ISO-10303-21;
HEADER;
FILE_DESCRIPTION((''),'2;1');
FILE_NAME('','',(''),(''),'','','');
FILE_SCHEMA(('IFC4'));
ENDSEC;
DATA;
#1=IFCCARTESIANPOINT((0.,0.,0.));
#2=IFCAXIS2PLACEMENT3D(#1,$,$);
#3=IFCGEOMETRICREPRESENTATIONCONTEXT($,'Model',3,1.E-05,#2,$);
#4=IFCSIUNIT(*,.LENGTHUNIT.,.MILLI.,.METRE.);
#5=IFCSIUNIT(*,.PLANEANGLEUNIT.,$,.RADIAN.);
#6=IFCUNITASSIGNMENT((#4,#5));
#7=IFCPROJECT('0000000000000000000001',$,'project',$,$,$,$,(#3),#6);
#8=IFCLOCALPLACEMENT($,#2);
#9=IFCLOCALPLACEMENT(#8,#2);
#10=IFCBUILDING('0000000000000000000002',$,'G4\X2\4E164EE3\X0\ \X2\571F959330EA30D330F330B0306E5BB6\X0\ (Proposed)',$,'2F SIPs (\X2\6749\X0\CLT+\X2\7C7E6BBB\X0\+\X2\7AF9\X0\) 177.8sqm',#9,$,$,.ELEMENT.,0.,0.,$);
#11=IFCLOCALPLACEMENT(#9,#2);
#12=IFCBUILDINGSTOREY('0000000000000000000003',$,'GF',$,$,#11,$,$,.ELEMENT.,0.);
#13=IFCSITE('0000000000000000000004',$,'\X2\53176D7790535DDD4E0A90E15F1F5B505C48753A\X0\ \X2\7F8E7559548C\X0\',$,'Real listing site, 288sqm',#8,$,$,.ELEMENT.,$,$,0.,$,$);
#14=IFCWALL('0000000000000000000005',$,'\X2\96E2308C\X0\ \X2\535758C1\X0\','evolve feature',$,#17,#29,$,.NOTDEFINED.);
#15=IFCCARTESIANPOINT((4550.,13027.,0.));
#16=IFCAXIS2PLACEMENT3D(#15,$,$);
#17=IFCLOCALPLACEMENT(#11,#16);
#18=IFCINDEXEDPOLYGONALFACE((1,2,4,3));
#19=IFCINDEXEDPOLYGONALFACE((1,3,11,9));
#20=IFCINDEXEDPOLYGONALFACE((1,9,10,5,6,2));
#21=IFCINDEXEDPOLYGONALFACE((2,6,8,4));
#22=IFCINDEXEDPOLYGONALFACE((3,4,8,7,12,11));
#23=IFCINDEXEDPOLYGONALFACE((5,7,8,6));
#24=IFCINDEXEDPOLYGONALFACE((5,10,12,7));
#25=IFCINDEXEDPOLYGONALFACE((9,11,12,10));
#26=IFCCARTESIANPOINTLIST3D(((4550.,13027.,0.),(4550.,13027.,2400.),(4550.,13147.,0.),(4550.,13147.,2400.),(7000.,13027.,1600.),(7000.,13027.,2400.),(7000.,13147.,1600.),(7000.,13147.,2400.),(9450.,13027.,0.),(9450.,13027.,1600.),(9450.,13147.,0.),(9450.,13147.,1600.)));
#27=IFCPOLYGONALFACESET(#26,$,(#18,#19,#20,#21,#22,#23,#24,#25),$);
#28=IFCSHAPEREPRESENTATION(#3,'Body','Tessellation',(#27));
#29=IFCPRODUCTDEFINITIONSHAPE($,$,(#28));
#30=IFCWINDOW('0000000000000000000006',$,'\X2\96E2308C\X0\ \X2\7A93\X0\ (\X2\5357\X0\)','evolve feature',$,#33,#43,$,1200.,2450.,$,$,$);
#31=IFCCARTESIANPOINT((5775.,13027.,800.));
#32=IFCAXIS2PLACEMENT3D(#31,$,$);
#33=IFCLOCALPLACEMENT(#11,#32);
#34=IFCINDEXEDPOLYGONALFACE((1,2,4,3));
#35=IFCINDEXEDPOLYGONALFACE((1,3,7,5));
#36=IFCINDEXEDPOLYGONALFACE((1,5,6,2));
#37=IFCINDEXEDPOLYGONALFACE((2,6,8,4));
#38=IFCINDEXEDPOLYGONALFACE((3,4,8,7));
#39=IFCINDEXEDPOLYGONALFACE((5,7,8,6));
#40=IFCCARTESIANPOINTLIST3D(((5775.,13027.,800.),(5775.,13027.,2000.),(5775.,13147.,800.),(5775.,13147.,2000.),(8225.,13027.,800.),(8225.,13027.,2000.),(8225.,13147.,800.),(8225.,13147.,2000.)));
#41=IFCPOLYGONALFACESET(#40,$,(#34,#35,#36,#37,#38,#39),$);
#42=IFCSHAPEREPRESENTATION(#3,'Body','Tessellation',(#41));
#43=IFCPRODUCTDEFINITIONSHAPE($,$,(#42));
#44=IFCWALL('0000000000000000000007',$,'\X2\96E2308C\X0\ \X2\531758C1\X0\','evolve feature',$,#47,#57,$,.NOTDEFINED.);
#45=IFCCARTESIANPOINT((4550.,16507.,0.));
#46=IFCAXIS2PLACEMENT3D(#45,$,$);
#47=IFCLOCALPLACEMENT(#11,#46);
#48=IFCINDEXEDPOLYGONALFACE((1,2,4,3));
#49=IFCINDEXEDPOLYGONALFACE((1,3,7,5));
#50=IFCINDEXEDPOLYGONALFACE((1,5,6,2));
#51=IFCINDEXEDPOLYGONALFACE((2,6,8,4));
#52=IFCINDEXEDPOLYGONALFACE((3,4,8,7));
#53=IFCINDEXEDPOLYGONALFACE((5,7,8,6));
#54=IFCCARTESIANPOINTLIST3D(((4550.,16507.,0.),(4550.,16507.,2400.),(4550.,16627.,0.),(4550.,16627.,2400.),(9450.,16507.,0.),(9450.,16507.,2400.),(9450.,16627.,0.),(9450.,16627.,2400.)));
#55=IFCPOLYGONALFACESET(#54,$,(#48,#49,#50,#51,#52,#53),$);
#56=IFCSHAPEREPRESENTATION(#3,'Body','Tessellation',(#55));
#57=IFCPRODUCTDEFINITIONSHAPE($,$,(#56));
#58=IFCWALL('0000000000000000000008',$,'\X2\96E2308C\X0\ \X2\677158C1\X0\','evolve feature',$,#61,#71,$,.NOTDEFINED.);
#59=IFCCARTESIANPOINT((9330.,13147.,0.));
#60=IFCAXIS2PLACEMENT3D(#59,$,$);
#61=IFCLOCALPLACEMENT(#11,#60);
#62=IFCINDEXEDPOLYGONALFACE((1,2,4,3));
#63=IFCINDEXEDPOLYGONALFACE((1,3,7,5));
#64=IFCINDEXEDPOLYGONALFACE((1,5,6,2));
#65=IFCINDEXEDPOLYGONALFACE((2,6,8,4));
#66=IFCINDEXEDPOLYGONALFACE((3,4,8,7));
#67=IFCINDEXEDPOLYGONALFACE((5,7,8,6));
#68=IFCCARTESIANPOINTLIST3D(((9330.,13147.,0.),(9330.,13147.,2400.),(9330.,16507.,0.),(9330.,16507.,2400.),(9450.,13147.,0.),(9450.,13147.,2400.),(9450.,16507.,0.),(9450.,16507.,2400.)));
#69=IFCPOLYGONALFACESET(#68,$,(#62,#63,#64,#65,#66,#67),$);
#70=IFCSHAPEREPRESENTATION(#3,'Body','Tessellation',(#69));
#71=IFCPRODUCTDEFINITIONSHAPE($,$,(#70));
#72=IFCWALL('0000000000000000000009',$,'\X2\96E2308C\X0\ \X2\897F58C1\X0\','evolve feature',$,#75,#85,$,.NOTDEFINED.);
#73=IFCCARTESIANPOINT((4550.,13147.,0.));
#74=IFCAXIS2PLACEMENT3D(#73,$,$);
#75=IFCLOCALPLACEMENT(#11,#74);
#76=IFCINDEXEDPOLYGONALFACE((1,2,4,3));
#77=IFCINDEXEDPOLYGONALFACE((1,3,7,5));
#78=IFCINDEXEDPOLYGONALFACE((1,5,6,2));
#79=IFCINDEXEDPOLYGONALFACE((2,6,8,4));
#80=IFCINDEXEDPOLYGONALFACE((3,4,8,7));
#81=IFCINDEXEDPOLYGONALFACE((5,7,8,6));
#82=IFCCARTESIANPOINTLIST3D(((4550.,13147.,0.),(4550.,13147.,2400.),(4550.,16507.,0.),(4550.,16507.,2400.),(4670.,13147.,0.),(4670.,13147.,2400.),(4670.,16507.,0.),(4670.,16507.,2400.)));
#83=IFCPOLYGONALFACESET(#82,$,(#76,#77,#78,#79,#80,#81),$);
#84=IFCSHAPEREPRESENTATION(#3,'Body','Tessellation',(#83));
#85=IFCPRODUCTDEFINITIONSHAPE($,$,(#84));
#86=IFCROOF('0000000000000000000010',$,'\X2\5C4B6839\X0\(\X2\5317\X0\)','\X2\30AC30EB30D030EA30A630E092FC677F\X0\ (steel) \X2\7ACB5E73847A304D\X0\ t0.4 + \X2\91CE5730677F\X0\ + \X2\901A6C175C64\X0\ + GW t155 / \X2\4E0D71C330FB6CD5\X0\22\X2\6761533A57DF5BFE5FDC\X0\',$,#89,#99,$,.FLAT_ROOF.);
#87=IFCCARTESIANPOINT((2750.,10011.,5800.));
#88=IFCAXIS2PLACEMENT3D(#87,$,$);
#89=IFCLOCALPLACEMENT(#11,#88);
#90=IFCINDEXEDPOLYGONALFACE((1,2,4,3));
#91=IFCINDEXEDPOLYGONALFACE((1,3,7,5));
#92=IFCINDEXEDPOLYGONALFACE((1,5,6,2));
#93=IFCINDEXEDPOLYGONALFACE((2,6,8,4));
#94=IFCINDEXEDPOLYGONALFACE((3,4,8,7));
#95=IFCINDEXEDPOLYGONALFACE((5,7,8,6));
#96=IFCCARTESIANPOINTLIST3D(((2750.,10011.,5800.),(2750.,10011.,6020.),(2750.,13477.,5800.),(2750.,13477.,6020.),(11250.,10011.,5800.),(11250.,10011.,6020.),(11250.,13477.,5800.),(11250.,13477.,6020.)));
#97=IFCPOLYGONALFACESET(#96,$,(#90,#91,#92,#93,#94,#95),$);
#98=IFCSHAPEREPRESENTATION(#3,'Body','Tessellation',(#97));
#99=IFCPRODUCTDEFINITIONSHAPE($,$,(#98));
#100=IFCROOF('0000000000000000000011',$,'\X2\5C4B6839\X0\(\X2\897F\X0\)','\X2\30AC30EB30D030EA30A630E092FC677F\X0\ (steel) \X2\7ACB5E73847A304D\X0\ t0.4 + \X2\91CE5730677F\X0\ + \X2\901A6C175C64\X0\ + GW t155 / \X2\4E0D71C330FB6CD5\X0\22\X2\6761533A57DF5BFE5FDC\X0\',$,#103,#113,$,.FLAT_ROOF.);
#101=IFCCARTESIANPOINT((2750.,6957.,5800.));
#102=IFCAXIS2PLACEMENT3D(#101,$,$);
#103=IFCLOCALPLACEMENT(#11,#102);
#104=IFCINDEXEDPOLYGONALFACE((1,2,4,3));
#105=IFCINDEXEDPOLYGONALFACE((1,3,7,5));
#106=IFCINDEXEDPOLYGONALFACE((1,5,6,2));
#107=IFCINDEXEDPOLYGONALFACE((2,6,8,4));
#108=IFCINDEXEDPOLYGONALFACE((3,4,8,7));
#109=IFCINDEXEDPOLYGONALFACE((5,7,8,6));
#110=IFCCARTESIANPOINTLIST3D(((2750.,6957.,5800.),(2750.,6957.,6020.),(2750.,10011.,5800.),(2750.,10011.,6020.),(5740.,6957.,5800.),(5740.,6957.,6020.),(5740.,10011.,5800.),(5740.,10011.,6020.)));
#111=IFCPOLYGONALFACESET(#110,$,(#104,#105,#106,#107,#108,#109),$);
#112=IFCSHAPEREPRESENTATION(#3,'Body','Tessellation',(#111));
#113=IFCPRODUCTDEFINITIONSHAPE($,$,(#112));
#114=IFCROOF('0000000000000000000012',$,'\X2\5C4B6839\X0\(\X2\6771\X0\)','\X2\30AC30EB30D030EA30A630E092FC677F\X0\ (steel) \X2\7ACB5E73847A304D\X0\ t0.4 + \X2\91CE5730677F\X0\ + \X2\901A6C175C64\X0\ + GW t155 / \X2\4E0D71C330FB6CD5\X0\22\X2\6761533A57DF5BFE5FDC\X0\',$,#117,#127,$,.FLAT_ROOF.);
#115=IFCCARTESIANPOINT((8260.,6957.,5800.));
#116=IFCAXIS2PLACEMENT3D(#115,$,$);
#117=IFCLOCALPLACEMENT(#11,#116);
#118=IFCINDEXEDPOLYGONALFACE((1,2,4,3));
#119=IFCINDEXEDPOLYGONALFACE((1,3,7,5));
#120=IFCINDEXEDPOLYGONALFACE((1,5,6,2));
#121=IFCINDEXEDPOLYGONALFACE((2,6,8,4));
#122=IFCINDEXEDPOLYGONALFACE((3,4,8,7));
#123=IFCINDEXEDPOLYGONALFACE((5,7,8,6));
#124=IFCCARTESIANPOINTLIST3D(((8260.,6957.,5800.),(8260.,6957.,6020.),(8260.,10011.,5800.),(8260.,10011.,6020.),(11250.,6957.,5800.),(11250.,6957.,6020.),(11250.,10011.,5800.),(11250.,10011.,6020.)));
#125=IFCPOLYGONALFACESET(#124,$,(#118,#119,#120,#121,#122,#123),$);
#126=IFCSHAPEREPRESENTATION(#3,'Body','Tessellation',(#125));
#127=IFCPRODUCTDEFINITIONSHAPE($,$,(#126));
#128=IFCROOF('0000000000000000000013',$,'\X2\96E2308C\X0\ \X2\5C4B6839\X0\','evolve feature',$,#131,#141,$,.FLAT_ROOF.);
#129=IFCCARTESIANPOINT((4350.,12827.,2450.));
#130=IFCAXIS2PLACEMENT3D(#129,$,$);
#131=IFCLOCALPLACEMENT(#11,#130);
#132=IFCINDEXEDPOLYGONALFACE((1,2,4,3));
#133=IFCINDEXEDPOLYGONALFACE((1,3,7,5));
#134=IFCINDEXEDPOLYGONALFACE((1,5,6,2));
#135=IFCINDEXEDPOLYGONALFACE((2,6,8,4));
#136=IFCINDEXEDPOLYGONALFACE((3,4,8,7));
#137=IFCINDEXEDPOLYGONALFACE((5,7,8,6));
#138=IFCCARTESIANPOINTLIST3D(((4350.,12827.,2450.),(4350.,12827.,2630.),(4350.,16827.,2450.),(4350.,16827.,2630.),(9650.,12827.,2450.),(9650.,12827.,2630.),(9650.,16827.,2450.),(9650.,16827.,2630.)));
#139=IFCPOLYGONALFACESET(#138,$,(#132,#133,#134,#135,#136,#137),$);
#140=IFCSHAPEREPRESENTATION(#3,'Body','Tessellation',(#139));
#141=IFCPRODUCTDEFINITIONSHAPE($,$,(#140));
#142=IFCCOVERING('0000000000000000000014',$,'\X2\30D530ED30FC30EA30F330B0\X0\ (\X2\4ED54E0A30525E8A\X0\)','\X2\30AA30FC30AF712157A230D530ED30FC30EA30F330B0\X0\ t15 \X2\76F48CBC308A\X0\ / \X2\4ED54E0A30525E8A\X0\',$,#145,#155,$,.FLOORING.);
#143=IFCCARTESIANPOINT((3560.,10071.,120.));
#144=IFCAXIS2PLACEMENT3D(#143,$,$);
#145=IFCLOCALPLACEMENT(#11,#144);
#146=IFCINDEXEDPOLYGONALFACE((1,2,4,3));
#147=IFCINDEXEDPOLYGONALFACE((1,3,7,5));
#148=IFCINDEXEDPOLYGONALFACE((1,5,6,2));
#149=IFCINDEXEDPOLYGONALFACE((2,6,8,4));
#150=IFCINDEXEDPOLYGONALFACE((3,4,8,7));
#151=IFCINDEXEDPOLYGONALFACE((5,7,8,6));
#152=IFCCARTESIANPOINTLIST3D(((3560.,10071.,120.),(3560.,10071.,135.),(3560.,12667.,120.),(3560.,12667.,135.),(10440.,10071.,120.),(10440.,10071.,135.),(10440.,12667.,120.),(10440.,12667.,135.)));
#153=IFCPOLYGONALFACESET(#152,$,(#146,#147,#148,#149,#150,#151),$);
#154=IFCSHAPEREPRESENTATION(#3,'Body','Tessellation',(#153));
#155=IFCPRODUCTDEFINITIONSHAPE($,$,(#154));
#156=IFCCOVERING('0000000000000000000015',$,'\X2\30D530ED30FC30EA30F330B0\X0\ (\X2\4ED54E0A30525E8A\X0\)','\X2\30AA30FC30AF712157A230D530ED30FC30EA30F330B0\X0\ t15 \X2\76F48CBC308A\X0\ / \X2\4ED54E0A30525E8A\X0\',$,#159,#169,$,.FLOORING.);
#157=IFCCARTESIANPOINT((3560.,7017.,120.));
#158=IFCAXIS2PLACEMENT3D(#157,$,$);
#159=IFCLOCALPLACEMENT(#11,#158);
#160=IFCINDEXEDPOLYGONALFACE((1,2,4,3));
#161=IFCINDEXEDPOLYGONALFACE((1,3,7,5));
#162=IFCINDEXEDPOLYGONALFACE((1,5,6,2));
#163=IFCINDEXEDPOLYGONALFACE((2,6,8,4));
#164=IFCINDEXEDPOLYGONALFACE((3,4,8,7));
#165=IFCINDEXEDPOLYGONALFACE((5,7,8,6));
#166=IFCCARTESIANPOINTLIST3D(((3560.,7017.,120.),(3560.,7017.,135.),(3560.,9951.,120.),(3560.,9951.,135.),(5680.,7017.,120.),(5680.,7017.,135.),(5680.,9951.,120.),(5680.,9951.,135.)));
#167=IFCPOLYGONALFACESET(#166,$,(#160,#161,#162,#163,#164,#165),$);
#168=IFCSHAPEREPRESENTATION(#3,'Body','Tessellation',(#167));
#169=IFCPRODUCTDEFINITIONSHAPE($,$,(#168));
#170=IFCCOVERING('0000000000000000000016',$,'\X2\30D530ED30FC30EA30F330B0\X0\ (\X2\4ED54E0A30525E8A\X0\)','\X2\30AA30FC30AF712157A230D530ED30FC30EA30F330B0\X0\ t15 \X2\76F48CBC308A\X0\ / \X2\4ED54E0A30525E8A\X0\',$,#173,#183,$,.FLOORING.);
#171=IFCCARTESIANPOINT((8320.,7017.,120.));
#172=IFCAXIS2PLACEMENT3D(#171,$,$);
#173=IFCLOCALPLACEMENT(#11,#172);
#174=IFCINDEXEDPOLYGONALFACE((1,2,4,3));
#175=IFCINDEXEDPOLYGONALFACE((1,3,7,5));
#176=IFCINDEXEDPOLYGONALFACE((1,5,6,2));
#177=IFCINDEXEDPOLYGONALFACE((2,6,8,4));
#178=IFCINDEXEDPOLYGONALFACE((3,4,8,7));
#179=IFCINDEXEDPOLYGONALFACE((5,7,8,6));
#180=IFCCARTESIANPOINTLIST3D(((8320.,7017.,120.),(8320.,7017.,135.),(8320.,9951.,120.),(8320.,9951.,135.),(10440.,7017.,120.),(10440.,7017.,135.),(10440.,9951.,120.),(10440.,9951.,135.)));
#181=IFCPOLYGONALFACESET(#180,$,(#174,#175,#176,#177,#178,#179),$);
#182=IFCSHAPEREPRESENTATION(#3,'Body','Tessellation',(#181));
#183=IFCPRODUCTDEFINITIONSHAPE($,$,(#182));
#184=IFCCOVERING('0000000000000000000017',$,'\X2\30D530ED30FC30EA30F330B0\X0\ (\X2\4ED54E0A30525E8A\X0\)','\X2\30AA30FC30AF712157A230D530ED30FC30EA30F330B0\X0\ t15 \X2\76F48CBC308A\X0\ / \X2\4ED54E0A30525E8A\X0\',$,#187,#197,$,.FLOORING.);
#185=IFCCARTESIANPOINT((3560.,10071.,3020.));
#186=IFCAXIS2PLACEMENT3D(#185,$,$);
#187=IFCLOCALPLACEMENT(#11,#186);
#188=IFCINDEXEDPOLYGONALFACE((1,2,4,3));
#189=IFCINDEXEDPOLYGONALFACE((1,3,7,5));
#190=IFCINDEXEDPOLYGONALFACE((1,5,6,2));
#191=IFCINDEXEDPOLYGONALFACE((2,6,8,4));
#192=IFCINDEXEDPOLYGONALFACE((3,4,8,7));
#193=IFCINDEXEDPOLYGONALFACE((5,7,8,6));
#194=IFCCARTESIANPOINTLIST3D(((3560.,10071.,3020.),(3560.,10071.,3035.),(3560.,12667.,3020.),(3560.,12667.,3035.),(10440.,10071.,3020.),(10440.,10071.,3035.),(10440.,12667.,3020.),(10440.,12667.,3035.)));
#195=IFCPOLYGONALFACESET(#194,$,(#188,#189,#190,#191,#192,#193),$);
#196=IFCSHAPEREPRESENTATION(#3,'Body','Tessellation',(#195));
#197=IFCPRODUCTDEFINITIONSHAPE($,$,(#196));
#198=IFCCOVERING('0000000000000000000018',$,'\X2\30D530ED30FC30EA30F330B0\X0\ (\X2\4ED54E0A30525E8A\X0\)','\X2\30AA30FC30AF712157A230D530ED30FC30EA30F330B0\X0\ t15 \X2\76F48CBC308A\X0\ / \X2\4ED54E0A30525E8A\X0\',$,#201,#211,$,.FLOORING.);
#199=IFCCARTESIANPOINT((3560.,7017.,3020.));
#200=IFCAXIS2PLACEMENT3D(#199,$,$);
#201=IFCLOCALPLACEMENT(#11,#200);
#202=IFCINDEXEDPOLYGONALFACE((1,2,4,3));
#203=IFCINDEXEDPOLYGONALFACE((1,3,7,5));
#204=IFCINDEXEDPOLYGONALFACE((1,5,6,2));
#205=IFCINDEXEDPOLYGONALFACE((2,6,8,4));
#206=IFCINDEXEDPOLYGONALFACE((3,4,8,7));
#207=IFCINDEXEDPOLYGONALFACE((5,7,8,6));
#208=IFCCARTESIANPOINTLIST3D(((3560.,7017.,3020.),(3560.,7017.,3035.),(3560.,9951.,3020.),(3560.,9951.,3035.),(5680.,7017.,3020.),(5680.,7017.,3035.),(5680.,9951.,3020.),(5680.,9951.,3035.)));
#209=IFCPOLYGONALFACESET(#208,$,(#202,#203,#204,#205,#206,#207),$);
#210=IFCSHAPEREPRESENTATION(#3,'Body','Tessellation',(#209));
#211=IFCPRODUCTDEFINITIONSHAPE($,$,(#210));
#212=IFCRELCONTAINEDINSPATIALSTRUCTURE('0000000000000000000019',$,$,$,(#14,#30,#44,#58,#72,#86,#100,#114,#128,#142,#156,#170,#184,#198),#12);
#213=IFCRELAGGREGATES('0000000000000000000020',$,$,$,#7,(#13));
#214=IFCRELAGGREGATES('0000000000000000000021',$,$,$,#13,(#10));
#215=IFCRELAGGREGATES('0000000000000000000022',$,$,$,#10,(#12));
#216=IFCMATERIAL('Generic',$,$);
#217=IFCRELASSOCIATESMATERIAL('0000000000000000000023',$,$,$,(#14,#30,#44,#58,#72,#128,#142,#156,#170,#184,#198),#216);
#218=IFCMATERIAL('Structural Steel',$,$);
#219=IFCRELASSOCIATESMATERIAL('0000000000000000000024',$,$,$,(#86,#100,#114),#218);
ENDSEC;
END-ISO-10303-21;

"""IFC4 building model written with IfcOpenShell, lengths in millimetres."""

from ifc_helpers import new_model, si_unit, frame, frame_2d, origin, place, context, project, spatial, rectangle, extrude, material, element, fill, save


model = new_model("IFC4")

# Units and contexts
model_context = context("Model", 3, precision=1e-05, world=origin())
ifc_project = project(units=[si_unit("LENGTHUNIT", "METRE", prefix="MILLI"), si_unit("PLANEANGLEUNIT", "RADIAN")], contexts=[model_context])

# Site, building, storey
site_placement = place(None, origin())
site = spatial("IfcSite", under=ifc_project, at=site_placement, Name="北海道川上郡弟子屈町 美留和", ObjectType="Real listing site, 288sqm", CompositionType="ELEMENT", RefElevation=0.0)
building_placement = place(site_placement, origin())
building = spatial("IfcBuilding", under=site, at=building_placement, Name="G4世代 土間リビングの家 (Proposed)", ObjectType="2F SIPs (杉CLT+籾殻+竹) 177.8sqm", CompositionType="ELEMENT", ElevationOfRefHeight=0.0, ElevationOfTerrain=0.0)
storey_placement = place(building_placement, origin())
storey = spatial("IfcBuildingStorey", under=building, at=storey_placement, Name="GF", CompositionType="ELEMENT", Elevation=0.0)

# Shared definitions
ifc_material_1 = material(Name="Generic")

# Wall, opening, window
wall_1_placement = place(storey_placement, frame((4550.0, 13027.0, 0.0)))
wall_1 = element("IfcWall", 1, at=wall_1_placement, inside=storey, material=ifc_material_1, Name="離れ 南壁", Description="evolve feature", PredefinedType="NOTDEFINED", context=model_context, shape_type="SweptSolid", body=[
    extrude(rectangle(XDim=4900.0, YDim=120.0, at=frame_2d((2450.0, 60.0))), frame((4550.0, 13027.0, 0.0)), (0.0, 0.0, 1.0), 2400.0),
])
opening_1_placement = place(storey_placement, frame((5775.0, 13027.0, 800.0)))
opening_1 = element("IfcOpeningElement", 2, at=opening_1_placement, cuts=wall_1, PredefinedType="NOTDEFINED", context=model_context, shape_type="SweptSolid", body=[
    extrude(rectangle(XDim=2450.0, YDim=120.0, at=frame_2d((1225.0, 60.0))), frame((5775.0, 13027.0, 800.0)), (0.0, 0.0, 1.0), 1200.0),
])
window_1_placement = place(storey_placement, frame((5775.0, 13027.0, 800.0)))
window_1 = element("IfcWindow", 3, at=window_1_placement, inside=storey, material=ifc_material_1, Name="離れ 窓 (南)", Description="evolve feature", OverallHeight=1200.0, OverallWidth=2450.0, context=model_context, shape_type="SweptSolid", body=[
    extrude(rectangle(XDim=2450.0, YDim=120.0, at=frame_2d((1225.0, 60.0))), frame((5775.0, 13027.0, 800.0)), (0.0, 0.0, 1.0), 1200.0),
])
fill(opening_1, window_1)

# Walls
wall_2_placement = place(storey_placement, frame((4550.0, 16507.0, 0.0)))
element("IfcWall", 4, at=wall_2_placement, inside=storey, material=ifc_material_1, Name="離れ 北壁", Description="evolve feature", PredefinedType="NOTDEFINED", context=model_context, shape_type="SweptSolid", body=[
    extrude(rectangle(XDim=4900.0, YDim=120.0, at=frame_2d((2450.0, 60.0))), frame((4550.0, 16507.0, 0.0)), (0.0, 0.0, 1.0), 2400.0),
])
wall_3_placement = place(storey_placement, frame((9330.0, 13147.0, 0.0)))
element("IfcWall", 5, at=wall_3_placement, inside=storey, material=ifc_material_1, Name="離れ 東壁", Description="evolve feature", PredefinedType="NOTDEFINED", context=model_context, shape_type="SweptSolid", body=[
    extrude(rectangle(XDim=120.0, YDim=3360.0, at=frame_2d((60.0, 1680.0))), frame((9330.0, 13147.0, 0.0)), (0.0, 0.0, 1.0), 2400.0),
])
wall_4_placement = place(storey_placement, frame((4550.0, 13147.0, 0.0)))
element("IfcWall", 6, at=wall_4_placement, inside=storey, material=ifc_material_1, Name="離れ 西壁", Description="evolve feature", PredefinedType="NOTDEFINED", context=model_context, shape_type="SweptSolid", body=[
    extrude(rectangle(XDim=120.0, YDim=3360.0, at=frame_2d((60.0, 1680.0))), frame((4550.0, 13147.0, 0.0)), (0.0, 0.0, 1.0), 2400.0),
])

# Roofs
ifc_material_2 = material(Name="Structural Steel")
for number, where, name in (
    (7, (2750.0, 10011.0, 5800.0), "屋根(北)"),
):
    element("IfcRoof", number, at=place(storey_placement, frame(where)), inside=storey, material=ifc_material_2, Name=name, Description="ガルバリウム鋼板 (steel) 立平葺き t0.4 + 野地板 + 通気層 + GW t155 / 不燃・法22条区域対応", PredefinedType="FLAT_ROOF", context=model_context, shape_type="SweptSolid", body=[
        extrude(rectangle(XDim=8500.0, YDim=3466.0, at=frame_2d((4250.0, 1733.0))), frame((2750.0, 10011.0, 5800.0)), (0.0, 0.0, 1.0), 220.0),
    ])
roof_1_placement = place(storey_placement, frame((2750.0, 6957.0, 5800.0)))
element("IfcRoof", 8, at=roof_1_placement, inside=storey, material=ifc_material_2, Name="屋根(西)", Description="ガルバリウム鋼板 (steel) 立平葺き t0.4 + 野地板 + 通気層 + GW t155 / 不燃・法22条区域対応", PredefinedType="FLAT_ROOF", context=model_context, shape_type="SweptSolid", body=[
    extrude(rectangle(XDim=2990.0, YDim=3054.0, at=frame_2d((1495.0, 1527.0))), frame((2750.0, 6957.0, 5800.0)), (0.0, 0.0, 1.0), 220.0),
])
roof_2_placement = place(storey_placement, frame((8260.0, 6957.0, 5800.0)))
element("IfcRoof", 9, at=roof_2_placement, inside=storey, material=ifc_material_2, Name="屋根(東)", Description="ガルバリウム鋼板 (steel) 立平葺き t0.4 + 野地板 + 通気層 + GW t155 / 不燃・法22条区域対応", PredefinedType="FLAT_ROOF", context=model_context, shape_type="SweptSolid", body=[
    extrude(rectangle(XDim=2990.0, YDim=3054.0, at=frame_2d((1495.0, 1527.0))), frame((8260.0, 6957.0, 5800.0)), (0.0, 0.0, 1.0), 220.0),
])
roof_3_placement = place(storey_placement, frame((4350.0, 12827.0, 2450.0)))
element("IfcRoof", 10, at=roof_3_placement, inside=storey, material=ifc_material_1, Name="離れ 屋根", Description="evolve feature", PredefinedType="FLAT_ROOF", context=model_context, shape_type="SweptSolid", body=[
    extrude(rectangle(XDim=5300.0, YDim=4000.0, at=frame_2d((2650.0, 2000.0))), frame((4350.0, 12827.0, 2450.0)), (0.0, 0.0, 1.0), 180.0),
])

# Coverings
covering_1_placement = place(storey_placement, frame((3560.0, 10071.0, 120.0)))
element("IfcCovering", 11, at=covering_1_placement, inside=storey, material=ifc_material_1, Name="フローリング (仕上げ床)", Description="オーク無垢フローリング t15 直貼り / 仕上げ床", PredefinedType="FLOORING", context=model_context, shape_type="SweptSolid", body=[
    extrude(rectangle(XDim=6880.0, YDim=2596.0, at=frame_2d((3440.0, 1298.0))), frame((3560.0, 10071.0, 120.0)), (0.0, 0.0, 1.0), 15.0),
])
covering_2_placement = place(storey_placement, frame((3560.0, 7017.0, 120.0)))
element("IfcCovering", 12, at=covering_2_placement, inside=storey, material=ifc_material_1, Name="フローリング (仕上げ床)", Description="オーク無垢フローリング t15 直貼り / 仕上げ床", PredefinedType="FLOORING", context=model_context, shape_type="SweptSolid", body=[
    extrude(rectangle(XDim=2120.0, YDim=2934.0, at=frame_2d((1060.0, 1467.0))), frame((3560.0, 7017.0, 120.0)), (0.0, 0.0, 1.0), 15.0),
])
covering_3_placement = place(storey_placement, frame((8320.0, 7017.0, 120.0)))
element("IfcCovering", 13, at=covering_3_placement, inside=storey, material=ifc_material_1, Name="フローリング (仕上げ床)", Description="オーク無垢フローリング t15 直貼り / 仕上げ床", PredefinedType="FLOORING", context=model_context, shape_type="SweptSolid", body=[
    extrude(rectangle(XDim=2120.0, YDim=2934.0, at=frame_2d((1060.0, 1467.0))), frame((8320.0, 7017.0, 120.0)), (0.0, 0.0, 1.0), 15.0),
])
covering_4_placement = place(storey_placement, frame((3560.0, 10071.0, 3020.0)))
element("IfcCovering", 14, at=covering_4_placement, inside=storey, material=ifc_material_1, Name="フローリング (仕上げ床)", Description="オーク無垢フローリング t15 直貼り / 仕上げ床", PredefinedType="FLOORING", context=model_context, shape_type="SweptSolid", body=[
    extrude(rectangle(XDim=6880.0, YDim=2596.0, at=frame_2d((3440.0, 1298.0))), frame((3560.0, 10071.0, 3020.0)), (0.0, 0.0, 1.0), 15.0),
])
covering_5_placement = place(storey_placement, frame((3560.0, 7017.0, 3020.0)))
element("IfcCovering", 15, at=covering_5_placement, inside=storey, material=ifc_material_1, Name="フローリング (仕上げ床)", Description="オーク無垢フローリング t15 直貼り / 仕上げ床", PredefinedType="FLOORING", context=model_context, shape_type="SweptSolid", body=[
    extrude(rectangle(XDim=2120.0, YDim=2934.0, at=frame_2d((1060.0, 1467.0))), frame((3560.0, 7017.0, 3020.0)), (0.0, 0.0, 1.0), 15.0),
])

save(model, "model.ifc")
